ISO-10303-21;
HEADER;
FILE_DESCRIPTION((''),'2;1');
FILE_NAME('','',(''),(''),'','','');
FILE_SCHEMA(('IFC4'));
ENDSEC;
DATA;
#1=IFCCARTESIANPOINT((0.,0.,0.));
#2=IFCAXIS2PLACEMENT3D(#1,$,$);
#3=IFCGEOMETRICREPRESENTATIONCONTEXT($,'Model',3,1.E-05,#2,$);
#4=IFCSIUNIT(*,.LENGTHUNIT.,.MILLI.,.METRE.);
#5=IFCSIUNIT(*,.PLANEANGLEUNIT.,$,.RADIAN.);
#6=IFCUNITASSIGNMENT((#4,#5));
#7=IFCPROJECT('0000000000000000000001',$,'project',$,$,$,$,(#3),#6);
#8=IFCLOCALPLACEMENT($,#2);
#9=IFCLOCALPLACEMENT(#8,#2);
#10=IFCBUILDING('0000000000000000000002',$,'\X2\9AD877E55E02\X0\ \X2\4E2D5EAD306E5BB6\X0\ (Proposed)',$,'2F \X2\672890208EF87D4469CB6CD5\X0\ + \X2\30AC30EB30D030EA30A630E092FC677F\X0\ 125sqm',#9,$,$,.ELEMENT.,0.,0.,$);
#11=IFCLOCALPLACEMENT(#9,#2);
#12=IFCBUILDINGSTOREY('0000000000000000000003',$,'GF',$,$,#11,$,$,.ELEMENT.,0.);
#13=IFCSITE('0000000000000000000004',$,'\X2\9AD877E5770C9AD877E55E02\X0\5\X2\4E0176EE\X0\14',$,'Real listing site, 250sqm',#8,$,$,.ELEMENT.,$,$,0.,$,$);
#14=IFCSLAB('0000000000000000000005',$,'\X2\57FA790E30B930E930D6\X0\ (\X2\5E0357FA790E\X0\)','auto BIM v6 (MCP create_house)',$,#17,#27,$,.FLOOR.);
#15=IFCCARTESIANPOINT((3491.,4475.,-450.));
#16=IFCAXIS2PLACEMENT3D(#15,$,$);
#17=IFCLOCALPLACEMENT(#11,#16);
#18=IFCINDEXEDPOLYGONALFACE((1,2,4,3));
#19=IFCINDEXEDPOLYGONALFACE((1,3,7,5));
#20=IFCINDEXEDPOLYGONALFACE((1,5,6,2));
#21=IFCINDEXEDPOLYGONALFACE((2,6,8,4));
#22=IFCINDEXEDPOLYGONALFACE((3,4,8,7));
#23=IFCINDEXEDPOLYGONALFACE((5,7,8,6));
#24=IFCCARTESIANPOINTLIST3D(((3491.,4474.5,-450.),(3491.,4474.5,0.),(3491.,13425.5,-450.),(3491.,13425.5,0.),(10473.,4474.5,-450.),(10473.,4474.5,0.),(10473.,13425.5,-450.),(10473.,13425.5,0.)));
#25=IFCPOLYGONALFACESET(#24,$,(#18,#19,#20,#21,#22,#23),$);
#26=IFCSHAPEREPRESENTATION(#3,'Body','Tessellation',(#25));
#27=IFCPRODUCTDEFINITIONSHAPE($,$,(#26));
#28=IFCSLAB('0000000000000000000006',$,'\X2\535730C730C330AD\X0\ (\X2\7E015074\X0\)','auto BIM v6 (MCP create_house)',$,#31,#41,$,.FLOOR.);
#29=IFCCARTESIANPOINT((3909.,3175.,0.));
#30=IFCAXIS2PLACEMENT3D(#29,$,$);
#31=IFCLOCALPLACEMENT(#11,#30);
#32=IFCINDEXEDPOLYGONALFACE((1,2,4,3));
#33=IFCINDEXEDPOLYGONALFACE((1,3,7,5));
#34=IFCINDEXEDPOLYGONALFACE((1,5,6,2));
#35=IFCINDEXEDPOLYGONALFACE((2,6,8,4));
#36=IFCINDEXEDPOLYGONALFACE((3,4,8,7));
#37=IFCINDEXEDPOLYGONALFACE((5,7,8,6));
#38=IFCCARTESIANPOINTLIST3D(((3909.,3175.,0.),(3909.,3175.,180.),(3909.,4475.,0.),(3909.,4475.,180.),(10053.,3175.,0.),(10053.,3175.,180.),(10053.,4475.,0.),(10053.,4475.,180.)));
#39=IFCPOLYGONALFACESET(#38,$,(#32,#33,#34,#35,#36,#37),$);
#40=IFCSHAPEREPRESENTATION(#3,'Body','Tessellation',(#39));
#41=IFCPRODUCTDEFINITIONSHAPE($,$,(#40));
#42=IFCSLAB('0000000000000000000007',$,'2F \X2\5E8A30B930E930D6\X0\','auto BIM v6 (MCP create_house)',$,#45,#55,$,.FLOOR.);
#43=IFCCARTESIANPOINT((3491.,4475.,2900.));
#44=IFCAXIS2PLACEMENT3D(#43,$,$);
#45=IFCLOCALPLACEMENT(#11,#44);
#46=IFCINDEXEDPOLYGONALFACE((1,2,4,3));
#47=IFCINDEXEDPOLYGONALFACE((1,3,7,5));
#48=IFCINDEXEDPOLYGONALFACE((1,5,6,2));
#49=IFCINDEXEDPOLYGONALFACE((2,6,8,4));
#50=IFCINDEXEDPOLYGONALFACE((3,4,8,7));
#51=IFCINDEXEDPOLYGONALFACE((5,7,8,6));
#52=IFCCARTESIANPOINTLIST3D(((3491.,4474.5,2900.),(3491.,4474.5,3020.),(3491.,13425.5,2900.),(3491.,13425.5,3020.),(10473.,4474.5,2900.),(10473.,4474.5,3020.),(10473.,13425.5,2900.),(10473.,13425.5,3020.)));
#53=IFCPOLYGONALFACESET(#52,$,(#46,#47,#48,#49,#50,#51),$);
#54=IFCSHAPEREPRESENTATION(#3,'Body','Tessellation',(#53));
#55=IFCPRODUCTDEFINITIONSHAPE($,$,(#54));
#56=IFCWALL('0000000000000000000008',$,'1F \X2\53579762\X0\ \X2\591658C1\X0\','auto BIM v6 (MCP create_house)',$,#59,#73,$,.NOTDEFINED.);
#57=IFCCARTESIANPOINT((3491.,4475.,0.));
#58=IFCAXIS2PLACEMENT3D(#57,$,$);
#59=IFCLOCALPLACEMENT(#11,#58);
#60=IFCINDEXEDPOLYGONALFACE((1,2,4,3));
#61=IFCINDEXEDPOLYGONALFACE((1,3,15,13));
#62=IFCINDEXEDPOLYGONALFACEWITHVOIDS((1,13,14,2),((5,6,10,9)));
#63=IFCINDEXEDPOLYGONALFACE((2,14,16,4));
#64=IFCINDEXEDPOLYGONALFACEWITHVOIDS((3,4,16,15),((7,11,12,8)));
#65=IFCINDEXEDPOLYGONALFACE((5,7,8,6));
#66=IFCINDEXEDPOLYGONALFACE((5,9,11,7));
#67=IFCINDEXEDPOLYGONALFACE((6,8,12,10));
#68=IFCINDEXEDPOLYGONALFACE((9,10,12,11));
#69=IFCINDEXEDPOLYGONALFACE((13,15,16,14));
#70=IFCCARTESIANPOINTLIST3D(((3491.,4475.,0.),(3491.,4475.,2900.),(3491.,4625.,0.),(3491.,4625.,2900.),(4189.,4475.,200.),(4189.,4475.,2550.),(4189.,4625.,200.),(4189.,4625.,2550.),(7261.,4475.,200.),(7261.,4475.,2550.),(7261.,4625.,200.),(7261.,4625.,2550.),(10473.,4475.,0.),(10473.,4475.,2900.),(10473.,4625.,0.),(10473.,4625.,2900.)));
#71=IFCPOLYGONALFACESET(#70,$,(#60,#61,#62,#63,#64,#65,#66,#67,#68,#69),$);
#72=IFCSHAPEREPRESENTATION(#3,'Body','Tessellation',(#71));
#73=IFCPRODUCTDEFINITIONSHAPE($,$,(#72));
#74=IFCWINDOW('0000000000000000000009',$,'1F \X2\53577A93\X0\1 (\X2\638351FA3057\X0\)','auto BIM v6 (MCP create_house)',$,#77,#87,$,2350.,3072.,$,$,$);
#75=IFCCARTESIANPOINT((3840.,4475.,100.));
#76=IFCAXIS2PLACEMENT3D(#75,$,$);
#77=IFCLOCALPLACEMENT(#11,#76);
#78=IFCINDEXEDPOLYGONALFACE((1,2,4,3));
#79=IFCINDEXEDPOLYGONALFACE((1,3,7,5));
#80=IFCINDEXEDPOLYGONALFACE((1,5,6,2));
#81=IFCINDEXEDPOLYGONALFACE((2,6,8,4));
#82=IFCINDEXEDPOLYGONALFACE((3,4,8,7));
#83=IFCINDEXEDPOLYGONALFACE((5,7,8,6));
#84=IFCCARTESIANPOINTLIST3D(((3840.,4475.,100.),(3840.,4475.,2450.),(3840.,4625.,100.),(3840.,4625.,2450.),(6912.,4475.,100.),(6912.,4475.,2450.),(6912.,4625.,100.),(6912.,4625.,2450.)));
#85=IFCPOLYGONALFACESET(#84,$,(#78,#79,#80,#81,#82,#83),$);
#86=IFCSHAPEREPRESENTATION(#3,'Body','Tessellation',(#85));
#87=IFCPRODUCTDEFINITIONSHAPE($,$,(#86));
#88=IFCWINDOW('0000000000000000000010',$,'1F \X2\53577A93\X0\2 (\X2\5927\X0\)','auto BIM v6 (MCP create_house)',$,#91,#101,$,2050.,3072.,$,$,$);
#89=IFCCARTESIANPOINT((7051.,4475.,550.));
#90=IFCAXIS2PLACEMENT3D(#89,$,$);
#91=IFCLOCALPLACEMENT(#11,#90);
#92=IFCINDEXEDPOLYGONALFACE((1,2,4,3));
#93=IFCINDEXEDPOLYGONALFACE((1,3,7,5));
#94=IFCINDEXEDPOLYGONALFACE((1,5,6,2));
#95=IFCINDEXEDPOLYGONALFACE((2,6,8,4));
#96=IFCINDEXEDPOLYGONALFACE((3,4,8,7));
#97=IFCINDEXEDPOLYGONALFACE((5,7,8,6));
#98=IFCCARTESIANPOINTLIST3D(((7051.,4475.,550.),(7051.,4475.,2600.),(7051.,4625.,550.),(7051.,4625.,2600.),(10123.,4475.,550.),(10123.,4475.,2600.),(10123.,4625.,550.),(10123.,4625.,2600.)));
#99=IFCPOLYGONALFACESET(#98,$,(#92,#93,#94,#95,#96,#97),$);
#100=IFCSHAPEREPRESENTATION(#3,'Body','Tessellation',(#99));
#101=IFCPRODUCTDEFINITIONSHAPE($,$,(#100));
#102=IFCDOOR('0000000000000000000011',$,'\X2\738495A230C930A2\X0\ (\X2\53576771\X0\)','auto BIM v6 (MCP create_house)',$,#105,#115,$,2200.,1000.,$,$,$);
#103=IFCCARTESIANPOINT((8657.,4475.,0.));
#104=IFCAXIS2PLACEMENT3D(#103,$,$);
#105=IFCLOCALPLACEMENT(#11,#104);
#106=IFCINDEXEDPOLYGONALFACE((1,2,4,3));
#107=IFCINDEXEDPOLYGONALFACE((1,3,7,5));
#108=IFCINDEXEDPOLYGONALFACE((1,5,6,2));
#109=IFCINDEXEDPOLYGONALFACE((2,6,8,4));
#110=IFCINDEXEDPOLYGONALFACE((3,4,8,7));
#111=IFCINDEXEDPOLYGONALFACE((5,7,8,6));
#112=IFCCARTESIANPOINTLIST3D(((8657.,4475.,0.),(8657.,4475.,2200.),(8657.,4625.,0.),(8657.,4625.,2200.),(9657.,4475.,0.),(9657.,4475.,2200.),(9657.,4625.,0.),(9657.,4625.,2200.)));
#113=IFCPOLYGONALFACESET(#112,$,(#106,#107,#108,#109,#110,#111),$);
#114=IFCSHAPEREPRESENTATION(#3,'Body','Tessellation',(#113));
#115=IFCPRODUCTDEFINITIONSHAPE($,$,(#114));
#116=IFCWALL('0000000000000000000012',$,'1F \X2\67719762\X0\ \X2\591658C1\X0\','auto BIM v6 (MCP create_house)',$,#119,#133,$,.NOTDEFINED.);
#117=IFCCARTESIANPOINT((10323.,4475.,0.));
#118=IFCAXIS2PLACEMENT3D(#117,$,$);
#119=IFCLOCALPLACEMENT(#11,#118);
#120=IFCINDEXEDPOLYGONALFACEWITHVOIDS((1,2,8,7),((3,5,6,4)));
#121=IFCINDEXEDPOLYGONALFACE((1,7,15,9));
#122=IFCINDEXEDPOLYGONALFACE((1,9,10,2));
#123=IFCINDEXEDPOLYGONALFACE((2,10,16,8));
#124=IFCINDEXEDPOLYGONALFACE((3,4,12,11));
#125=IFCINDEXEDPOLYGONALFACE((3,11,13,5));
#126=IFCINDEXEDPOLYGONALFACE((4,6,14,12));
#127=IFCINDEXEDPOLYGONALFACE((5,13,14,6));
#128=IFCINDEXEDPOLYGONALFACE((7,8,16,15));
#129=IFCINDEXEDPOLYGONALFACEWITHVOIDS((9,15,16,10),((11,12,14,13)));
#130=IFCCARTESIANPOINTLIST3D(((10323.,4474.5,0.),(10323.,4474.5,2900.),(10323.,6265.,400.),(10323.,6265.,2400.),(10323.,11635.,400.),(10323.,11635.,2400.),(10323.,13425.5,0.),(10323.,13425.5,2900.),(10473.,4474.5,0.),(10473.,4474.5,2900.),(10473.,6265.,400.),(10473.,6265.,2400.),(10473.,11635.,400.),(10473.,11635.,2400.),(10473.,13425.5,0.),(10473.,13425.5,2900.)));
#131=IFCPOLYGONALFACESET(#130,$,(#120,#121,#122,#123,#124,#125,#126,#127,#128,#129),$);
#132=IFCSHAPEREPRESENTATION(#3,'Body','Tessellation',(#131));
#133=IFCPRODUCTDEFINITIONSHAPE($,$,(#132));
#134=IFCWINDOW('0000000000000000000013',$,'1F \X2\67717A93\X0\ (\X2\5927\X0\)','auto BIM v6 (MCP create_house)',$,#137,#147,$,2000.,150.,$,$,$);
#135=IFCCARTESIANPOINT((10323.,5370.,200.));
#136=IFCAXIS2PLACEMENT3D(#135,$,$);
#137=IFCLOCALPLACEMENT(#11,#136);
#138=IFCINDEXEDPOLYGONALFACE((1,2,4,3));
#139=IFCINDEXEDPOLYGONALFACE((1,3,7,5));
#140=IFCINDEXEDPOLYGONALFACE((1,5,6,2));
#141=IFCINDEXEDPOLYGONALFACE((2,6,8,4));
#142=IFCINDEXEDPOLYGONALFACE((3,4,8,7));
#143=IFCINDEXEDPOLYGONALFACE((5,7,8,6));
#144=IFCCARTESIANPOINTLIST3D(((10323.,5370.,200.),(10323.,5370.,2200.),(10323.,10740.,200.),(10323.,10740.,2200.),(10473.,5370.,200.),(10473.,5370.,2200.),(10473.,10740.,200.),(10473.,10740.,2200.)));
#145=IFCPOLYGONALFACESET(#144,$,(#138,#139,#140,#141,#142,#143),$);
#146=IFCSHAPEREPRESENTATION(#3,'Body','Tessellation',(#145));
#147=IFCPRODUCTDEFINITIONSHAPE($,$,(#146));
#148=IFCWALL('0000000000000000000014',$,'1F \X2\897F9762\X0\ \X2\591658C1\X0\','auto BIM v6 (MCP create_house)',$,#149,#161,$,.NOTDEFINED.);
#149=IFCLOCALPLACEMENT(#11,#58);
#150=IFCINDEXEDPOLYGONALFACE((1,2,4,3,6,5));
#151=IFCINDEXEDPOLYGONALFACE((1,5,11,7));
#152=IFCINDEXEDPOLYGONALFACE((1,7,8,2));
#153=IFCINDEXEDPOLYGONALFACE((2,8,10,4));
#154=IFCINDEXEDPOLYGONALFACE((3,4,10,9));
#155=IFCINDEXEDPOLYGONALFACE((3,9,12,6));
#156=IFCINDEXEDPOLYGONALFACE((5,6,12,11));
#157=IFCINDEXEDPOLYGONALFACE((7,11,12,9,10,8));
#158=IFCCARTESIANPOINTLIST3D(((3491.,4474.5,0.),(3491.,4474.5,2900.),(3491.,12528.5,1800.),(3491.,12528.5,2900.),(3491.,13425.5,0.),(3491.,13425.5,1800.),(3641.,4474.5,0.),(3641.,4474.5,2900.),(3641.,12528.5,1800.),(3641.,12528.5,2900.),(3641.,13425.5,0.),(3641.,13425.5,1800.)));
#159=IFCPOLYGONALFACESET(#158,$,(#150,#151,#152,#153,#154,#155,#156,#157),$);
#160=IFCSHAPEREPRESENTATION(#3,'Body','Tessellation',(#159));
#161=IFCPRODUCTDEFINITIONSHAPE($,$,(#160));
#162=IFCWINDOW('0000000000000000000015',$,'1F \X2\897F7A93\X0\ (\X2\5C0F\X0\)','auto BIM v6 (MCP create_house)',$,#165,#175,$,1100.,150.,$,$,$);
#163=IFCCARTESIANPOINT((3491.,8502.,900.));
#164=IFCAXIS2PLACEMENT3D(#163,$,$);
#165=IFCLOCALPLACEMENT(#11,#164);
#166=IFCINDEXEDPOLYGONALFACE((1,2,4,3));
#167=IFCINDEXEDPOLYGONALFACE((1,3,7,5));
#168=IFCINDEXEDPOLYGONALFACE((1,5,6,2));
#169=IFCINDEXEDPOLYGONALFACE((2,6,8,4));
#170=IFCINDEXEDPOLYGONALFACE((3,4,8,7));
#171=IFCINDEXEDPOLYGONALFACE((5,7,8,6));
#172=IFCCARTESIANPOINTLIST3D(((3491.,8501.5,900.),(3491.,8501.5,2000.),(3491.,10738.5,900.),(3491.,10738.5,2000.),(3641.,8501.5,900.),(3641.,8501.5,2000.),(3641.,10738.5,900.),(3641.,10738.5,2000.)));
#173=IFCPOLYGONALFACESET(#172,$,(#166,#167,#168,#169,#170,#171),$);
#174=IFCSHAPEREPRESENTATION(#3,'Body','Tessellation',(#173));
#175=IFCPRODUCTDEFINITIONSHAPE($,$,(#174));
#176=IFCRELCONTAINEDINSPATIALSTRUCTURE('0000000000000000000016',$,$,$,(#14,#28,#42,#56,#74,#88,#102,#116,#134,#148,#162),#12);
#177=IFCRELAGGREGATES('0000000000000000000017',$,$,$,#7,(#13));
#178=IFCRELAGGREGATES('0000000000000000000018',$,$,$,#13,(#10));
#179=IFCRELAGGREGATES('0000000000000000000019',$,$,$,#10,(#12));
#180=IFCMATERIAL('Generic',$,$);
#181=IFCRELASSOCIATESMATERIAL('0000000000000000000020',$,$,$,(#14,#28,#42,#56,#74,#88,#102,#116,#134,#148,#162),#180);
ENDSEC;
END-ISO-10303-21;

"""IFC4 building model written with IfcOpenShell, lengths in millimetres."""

from ifc_helpers import new_model, si_unit, frame, frame_2d, origin, place, context, project, spatial, rectangle, extrude, material, element, fill, save


model = new_model("IFC4")

# Units and contexts
model_context = context("Model", 3, precision=1e-05, world=origin())
ifc_project = project(units=[si_unit("LENGTHUNIT", "METRE", prefix="MILLI"), si_unit("PLANEANGLEUNIT", "RADIAN")], contexts=[model_context])

# Site, building, storey
site_placement = place(None, origin())
site = spatial("IfcSite", under=ifc_project, at=site_placement, Name="高知県高知市5丁目14", ObjectType="Real listing site, 250sqm", CompositionType="ELEMENT", RefElevation=0.0)
building_placement = place(site_placement, origin())
building = spatial("IfcBuilding", under=site, at=building_placement, Name="高知市 中庭の家 (Proposed)", ObjectType="2F 木造軸組構法 + ガルバリウム鋼板 125sqm", CompositionType="ELEMENT", ElevationOfRefHeight=0.0, ElevationOfTerrain=0.0)
storey_placement = place(building_placement, origin())
storey = spatial("IfcBuildingStorey", under=building, at=storey_placement, Name="GF", CompositionType="ELEMENT", Elevation=0.0)

# Slabs
ifc_material = material(Name="Generic")
slab_1_placement = place(storey_placement, frame((3491.0, 4475.0, -450.0)))
element("IfcSlab", 1, at=slab_1_placement, inside=storey, material=ifc_material, Name="基礎スラブ (布基礎)", Description="auto BIM v6 (MCP create_house)", PredefinedType="FLOOR", context=model_context, shape_type="SweptSolid", body=[
    extrude(rectangle(XDim=6982.0, YDim=8951.0, at=frame_2d((3491.0, 4475.0))), frame((3491.0, 4475.0, -450.0)), (0.0, 0.0, 1.0), 450.0),
])
slab_2_placement = place(storey_placement, frame((3909.0, 3175.0, 0.0)))
element("IfcSlab", 2, at=slab_2_placement, inside=storey, material=ifc_material, Name="南デッキ (縁側)", Description="auto BIM v6 (MCP create_house)", PredefinedType="FLOOR", context=model_context, shape_type="SweptSolid", body=[
    extrude(rectangle(XDim=6144.0, YDim=1300.0, at=frame_2d((3072.0, 650.0))), frame((3909.0, 3175.0, 0.0)), (0.0, 0.0, 1.0), 180.0),
])
slab_3_placement = place(storey_placement, frame((3491.0, 4475.0, 2900.0)))
element("IfcSlab", 3, at=slab_3_placement, inside=storey, material=ifc_material, Name="2F 床スラブ", Description="auto BIM v6 (MCP create_house)", PredefinedType="FLOOR", context=model_context, shape_type="SweptSolid", body=[
    extrude(rectangle(XDim=6982.0, YDim=8951.0, at=frame_2d((3491.0, 4475.0))), frame((3491.0, 4475.0, 2900.0)), (0.0, 0.0, 1.0), 120.0),
])

# Wall, openings, windows, door
wall_1_placement = place(storey_placement, frame((3491.0, 4475.0, 0.0)))
wall_1 = element("IfcWall", 4, at=wall_1_placement, inside=storey, material=ifc_material, Name="1F 南面 外壁", Description="auto BIM v6 (MCP create_house)", PredefinedType="NOTDEFINED", context=model_context, shape_type="SweptSolid", body=[
    extrude(rectangle(XDim=6982.0, YDim=150.0, at=frame_2d((3491.0, 75.0))), frame((3491.0, 4475.0, 0.0)), (0.0, 0.0, 1.0), 2900.0),
])
opening_1_placement = place(storey_placement, frame((3840.0, 4475.0, 100.0)))
opening_1 = element("IfcOpeningElement", 5, at=opening_1_placement, cuts=wall_1, PredefinedType="NOTDEFINED", context=model_context, shape_type="SweptSolid", body=[
    extrude(rectangle(XDim=3072.0, YDim=150.0, at=frame_2d((1536.0, 75.0))), frame((3840.0, 4475.0, 100.0)), (0.0, 0.0, 1.0), 2350.0),
])
opening_2_placement = place(storey_placement, frame((7051.0, 4475.0, 550.0)))
opening_2 = element("IfcOpeningElement", 6, at=opening_2_placement, cuts=wall_1, PredefinedType="NOTDEFINED", context=model_context, shape_type="SweptSolid", body=[
    extrude(rectangle(XDim=3072.0, YDim=150.0, at=frame_2d((1536.0, 75.0))), frame((7051.0, 4475.0, 550.0)), (0.0, 0.0, 1.0), 2050.0),
])
opening_3_placement = place(storey_placement, frame((8657.0, 4475.0, 0.0)))
opening_3 = element("IfcOpeningElement", 7, at=opening_3_placement, cuts=wall_1, PredefinedType="NOTDEFINED", context=model_context, shape_type="SweptSolid", body=[
    extrude(rectangle(XDim=1000.0, YDim=150.0, at=frame_2d((500.0, 75.0))), frame((8657.0, 4475.0, 0.0)), (0.0, 0.0, 1.0), 2200.0),
])
window_1_placement = place(storey_placement, frame((3840.0, 4475.0, 100.0)))
window_1 = element("IfcWindow", 8, at=window_1_placement, inside=storey, material=ifc_material, Name="1F 南窓1 (掃出し)", Description="auto BIM v6 (MCP create_house)", OverallHeight=2350.0, OverallWidth=3072.0, context=model_context, shape_type="SweptSolid", body=[
    extrude(rectangle(XDim=3072.0, YDim=150.0, at=frame_2d((1536.0, 75.0))), frame((3840.0, 4475.0, 100.0)), (0.0, 0.0, 1.0), 2350.0),
])
fill(opening_1, window_1)
window_2_placement = place(storey_placement, frame((7051.0, 4475.0, 550.0)))
window_2 = element("IfcWindow", 9, at=window_2_placement, inside=storey, material=ifc_material, Name="1F 南窓2 (大)", Description="auto BIM v6 (MCP create_house)", OverallHeight=2050.0, OverallWidth=3072.0, context=model_context, shape_type="SweptSolid", body=[
    extrude(rectangle(XDim=3072.0, YDim=150.0, at=frame_2d((1536.0, 75.0))), frame((7051.0, 4475.0, 550.0)), (0.0, 0.0, 1.0), 2050.0),
])
fill(opening_2, window_2)
door_placement = place(storey_placement, frame((8657.0, 4475.0, 0.0)))
door = element("IfcDoor", 10, at=door_placement, inside=storey, material=ifc_material, Name="玄関ドア (南東)", Description="auto BIM v6 (MCP create_house)", OverallHeight=2200.0, OverallWidth=1000.0, context=model_context, shape_type="SweptSolid", body=[
    extrude(rectangle(XDim=1000.0, YDim=150.0, at=frame_2d((500.0, 75.0))), frame((8657.0, 4475.0, 0.0)), (0.0, 0.0, 1.0), 2200.0),
])
fill(opening_3, door)

# Walls, openings, windows
wall_2_placement = place(storey_placement, frame((10323.0, 4475.0, 0.0)))
wall_2 = element("IfcWall", 11, at=wall_2_placement, inside=storey, material=ifc_material, Name="1F 東面 外壁", Description="auto BIM v6 (MCP create_house)", PredefinedType="NOTDEFINED", context=model_context, shape_type="SweptSolid", body=[
    extrude(rectangle(XDim=150.0, YDim=8951.0, at=frame_2d((75.0, 4475.0))), frame((10323.0, 4475.0, 0.0)), (0.0, 0.0, 1.0), 2900.0),
])
opening_4_placement = place(storey_placement, frame((10323.0, 5370.0, 200.0)))
opening_4 = element("IfcOpeningElement", 12, at=opening_4_placement, cuts=wall_2, PredefinedType="NOTDEFINED", context=model_context, shape_type="SweptSolid", body=[
    extrude(rectangle(XDim=150.0, YDim=5370.0, at=frame_2d((75.0, 2685.0))), frame((10323.0, 5370.0, 200.0)), (0.0, 0.0, 1.0), 2000.0),
])
window_3_placement = place(storey_placement, frame((10323.0, 5370.0, 200.0)))
window_3 = element("IfcWindow", 13, at=window_3_placement, inside=storey, material=ifc_material, Name="1F 東窓 (大)", Description="auto BIM v6 (MCP create_house)", OverallHeight=2000.0, OverallWidth=150.0, context=model_context, shape_type="SweptSolid", body=[
    extrude(rectangle(XDim=150.0, YDim=5370.0, at=frame_2d((75.0, 2685.0))), frame((10323.0, 5370.0, 200.0)), (0.0, 0.0, 1.0), 2000.0),
])
fill(opening_4, window_3)
wall_3_placement = place(storey_placement, frame((3491.0, 4475.0, 0.0)))
wall_3 = element("IfcWall", 14, at=wall_3_placement, inside=storey, material=ifc_material, Name="1F 西面 外壁", Description="auto BIM v6 (MCP create_house)", PredefinedType="NOTDEFINED", context=model_context, shape_type="SweptSolid", body=[
    extrude(rectangle(XDim=150.0, YDim=8951.0, at=frame_2d((75.0, 4475.0))), frame((3491.0, 4475.0, 0.0)), (0.0, 0.0, 1.0), 2900.0),
])
opening_5_placement = place(storey_placement, frame((3491.0, 8502.0, 900.0)))
opening_5 = element("IfcOpeningElement", 15, at=opening_5_placement, cuts=wall_3, PredefinedType="NOTDEFINED", context=model_context, shape_type="SweptSolid", body=[
    extrude(rectangle(XDim=150.0, YDim=2237.0, at=frame_2d((75.0, 1118.0))), frame((3491.0, 8502.0, 900.0)), (0.0, 0.0, 1.0), 1100.0),
])
window_4_placement = place(storey_placement, frame((3491.0, 8502.0, 900.0)))
window_4 = element("IfcWindow", 16, at=window_4_placement, inside=storey, material=ifc_material, Name="1F 西窓 (小)", Description="auto BIM v6 (MCP create_house)", OverallHeight=1100.0, OverallWidth=150.0, context=model_context, shape_type="SweptSolid", body=[
    extrude(rectangle(XDim=150.0, YDim=2237.0, at=frame_2d((75.0, 1118.0))), frame((3491.0, 8502.0, 900.0)), (0.0, 0.0, 1.0), 1100.0),
])
fill(opening_5, window_4)

save(model, "model.ifc")
